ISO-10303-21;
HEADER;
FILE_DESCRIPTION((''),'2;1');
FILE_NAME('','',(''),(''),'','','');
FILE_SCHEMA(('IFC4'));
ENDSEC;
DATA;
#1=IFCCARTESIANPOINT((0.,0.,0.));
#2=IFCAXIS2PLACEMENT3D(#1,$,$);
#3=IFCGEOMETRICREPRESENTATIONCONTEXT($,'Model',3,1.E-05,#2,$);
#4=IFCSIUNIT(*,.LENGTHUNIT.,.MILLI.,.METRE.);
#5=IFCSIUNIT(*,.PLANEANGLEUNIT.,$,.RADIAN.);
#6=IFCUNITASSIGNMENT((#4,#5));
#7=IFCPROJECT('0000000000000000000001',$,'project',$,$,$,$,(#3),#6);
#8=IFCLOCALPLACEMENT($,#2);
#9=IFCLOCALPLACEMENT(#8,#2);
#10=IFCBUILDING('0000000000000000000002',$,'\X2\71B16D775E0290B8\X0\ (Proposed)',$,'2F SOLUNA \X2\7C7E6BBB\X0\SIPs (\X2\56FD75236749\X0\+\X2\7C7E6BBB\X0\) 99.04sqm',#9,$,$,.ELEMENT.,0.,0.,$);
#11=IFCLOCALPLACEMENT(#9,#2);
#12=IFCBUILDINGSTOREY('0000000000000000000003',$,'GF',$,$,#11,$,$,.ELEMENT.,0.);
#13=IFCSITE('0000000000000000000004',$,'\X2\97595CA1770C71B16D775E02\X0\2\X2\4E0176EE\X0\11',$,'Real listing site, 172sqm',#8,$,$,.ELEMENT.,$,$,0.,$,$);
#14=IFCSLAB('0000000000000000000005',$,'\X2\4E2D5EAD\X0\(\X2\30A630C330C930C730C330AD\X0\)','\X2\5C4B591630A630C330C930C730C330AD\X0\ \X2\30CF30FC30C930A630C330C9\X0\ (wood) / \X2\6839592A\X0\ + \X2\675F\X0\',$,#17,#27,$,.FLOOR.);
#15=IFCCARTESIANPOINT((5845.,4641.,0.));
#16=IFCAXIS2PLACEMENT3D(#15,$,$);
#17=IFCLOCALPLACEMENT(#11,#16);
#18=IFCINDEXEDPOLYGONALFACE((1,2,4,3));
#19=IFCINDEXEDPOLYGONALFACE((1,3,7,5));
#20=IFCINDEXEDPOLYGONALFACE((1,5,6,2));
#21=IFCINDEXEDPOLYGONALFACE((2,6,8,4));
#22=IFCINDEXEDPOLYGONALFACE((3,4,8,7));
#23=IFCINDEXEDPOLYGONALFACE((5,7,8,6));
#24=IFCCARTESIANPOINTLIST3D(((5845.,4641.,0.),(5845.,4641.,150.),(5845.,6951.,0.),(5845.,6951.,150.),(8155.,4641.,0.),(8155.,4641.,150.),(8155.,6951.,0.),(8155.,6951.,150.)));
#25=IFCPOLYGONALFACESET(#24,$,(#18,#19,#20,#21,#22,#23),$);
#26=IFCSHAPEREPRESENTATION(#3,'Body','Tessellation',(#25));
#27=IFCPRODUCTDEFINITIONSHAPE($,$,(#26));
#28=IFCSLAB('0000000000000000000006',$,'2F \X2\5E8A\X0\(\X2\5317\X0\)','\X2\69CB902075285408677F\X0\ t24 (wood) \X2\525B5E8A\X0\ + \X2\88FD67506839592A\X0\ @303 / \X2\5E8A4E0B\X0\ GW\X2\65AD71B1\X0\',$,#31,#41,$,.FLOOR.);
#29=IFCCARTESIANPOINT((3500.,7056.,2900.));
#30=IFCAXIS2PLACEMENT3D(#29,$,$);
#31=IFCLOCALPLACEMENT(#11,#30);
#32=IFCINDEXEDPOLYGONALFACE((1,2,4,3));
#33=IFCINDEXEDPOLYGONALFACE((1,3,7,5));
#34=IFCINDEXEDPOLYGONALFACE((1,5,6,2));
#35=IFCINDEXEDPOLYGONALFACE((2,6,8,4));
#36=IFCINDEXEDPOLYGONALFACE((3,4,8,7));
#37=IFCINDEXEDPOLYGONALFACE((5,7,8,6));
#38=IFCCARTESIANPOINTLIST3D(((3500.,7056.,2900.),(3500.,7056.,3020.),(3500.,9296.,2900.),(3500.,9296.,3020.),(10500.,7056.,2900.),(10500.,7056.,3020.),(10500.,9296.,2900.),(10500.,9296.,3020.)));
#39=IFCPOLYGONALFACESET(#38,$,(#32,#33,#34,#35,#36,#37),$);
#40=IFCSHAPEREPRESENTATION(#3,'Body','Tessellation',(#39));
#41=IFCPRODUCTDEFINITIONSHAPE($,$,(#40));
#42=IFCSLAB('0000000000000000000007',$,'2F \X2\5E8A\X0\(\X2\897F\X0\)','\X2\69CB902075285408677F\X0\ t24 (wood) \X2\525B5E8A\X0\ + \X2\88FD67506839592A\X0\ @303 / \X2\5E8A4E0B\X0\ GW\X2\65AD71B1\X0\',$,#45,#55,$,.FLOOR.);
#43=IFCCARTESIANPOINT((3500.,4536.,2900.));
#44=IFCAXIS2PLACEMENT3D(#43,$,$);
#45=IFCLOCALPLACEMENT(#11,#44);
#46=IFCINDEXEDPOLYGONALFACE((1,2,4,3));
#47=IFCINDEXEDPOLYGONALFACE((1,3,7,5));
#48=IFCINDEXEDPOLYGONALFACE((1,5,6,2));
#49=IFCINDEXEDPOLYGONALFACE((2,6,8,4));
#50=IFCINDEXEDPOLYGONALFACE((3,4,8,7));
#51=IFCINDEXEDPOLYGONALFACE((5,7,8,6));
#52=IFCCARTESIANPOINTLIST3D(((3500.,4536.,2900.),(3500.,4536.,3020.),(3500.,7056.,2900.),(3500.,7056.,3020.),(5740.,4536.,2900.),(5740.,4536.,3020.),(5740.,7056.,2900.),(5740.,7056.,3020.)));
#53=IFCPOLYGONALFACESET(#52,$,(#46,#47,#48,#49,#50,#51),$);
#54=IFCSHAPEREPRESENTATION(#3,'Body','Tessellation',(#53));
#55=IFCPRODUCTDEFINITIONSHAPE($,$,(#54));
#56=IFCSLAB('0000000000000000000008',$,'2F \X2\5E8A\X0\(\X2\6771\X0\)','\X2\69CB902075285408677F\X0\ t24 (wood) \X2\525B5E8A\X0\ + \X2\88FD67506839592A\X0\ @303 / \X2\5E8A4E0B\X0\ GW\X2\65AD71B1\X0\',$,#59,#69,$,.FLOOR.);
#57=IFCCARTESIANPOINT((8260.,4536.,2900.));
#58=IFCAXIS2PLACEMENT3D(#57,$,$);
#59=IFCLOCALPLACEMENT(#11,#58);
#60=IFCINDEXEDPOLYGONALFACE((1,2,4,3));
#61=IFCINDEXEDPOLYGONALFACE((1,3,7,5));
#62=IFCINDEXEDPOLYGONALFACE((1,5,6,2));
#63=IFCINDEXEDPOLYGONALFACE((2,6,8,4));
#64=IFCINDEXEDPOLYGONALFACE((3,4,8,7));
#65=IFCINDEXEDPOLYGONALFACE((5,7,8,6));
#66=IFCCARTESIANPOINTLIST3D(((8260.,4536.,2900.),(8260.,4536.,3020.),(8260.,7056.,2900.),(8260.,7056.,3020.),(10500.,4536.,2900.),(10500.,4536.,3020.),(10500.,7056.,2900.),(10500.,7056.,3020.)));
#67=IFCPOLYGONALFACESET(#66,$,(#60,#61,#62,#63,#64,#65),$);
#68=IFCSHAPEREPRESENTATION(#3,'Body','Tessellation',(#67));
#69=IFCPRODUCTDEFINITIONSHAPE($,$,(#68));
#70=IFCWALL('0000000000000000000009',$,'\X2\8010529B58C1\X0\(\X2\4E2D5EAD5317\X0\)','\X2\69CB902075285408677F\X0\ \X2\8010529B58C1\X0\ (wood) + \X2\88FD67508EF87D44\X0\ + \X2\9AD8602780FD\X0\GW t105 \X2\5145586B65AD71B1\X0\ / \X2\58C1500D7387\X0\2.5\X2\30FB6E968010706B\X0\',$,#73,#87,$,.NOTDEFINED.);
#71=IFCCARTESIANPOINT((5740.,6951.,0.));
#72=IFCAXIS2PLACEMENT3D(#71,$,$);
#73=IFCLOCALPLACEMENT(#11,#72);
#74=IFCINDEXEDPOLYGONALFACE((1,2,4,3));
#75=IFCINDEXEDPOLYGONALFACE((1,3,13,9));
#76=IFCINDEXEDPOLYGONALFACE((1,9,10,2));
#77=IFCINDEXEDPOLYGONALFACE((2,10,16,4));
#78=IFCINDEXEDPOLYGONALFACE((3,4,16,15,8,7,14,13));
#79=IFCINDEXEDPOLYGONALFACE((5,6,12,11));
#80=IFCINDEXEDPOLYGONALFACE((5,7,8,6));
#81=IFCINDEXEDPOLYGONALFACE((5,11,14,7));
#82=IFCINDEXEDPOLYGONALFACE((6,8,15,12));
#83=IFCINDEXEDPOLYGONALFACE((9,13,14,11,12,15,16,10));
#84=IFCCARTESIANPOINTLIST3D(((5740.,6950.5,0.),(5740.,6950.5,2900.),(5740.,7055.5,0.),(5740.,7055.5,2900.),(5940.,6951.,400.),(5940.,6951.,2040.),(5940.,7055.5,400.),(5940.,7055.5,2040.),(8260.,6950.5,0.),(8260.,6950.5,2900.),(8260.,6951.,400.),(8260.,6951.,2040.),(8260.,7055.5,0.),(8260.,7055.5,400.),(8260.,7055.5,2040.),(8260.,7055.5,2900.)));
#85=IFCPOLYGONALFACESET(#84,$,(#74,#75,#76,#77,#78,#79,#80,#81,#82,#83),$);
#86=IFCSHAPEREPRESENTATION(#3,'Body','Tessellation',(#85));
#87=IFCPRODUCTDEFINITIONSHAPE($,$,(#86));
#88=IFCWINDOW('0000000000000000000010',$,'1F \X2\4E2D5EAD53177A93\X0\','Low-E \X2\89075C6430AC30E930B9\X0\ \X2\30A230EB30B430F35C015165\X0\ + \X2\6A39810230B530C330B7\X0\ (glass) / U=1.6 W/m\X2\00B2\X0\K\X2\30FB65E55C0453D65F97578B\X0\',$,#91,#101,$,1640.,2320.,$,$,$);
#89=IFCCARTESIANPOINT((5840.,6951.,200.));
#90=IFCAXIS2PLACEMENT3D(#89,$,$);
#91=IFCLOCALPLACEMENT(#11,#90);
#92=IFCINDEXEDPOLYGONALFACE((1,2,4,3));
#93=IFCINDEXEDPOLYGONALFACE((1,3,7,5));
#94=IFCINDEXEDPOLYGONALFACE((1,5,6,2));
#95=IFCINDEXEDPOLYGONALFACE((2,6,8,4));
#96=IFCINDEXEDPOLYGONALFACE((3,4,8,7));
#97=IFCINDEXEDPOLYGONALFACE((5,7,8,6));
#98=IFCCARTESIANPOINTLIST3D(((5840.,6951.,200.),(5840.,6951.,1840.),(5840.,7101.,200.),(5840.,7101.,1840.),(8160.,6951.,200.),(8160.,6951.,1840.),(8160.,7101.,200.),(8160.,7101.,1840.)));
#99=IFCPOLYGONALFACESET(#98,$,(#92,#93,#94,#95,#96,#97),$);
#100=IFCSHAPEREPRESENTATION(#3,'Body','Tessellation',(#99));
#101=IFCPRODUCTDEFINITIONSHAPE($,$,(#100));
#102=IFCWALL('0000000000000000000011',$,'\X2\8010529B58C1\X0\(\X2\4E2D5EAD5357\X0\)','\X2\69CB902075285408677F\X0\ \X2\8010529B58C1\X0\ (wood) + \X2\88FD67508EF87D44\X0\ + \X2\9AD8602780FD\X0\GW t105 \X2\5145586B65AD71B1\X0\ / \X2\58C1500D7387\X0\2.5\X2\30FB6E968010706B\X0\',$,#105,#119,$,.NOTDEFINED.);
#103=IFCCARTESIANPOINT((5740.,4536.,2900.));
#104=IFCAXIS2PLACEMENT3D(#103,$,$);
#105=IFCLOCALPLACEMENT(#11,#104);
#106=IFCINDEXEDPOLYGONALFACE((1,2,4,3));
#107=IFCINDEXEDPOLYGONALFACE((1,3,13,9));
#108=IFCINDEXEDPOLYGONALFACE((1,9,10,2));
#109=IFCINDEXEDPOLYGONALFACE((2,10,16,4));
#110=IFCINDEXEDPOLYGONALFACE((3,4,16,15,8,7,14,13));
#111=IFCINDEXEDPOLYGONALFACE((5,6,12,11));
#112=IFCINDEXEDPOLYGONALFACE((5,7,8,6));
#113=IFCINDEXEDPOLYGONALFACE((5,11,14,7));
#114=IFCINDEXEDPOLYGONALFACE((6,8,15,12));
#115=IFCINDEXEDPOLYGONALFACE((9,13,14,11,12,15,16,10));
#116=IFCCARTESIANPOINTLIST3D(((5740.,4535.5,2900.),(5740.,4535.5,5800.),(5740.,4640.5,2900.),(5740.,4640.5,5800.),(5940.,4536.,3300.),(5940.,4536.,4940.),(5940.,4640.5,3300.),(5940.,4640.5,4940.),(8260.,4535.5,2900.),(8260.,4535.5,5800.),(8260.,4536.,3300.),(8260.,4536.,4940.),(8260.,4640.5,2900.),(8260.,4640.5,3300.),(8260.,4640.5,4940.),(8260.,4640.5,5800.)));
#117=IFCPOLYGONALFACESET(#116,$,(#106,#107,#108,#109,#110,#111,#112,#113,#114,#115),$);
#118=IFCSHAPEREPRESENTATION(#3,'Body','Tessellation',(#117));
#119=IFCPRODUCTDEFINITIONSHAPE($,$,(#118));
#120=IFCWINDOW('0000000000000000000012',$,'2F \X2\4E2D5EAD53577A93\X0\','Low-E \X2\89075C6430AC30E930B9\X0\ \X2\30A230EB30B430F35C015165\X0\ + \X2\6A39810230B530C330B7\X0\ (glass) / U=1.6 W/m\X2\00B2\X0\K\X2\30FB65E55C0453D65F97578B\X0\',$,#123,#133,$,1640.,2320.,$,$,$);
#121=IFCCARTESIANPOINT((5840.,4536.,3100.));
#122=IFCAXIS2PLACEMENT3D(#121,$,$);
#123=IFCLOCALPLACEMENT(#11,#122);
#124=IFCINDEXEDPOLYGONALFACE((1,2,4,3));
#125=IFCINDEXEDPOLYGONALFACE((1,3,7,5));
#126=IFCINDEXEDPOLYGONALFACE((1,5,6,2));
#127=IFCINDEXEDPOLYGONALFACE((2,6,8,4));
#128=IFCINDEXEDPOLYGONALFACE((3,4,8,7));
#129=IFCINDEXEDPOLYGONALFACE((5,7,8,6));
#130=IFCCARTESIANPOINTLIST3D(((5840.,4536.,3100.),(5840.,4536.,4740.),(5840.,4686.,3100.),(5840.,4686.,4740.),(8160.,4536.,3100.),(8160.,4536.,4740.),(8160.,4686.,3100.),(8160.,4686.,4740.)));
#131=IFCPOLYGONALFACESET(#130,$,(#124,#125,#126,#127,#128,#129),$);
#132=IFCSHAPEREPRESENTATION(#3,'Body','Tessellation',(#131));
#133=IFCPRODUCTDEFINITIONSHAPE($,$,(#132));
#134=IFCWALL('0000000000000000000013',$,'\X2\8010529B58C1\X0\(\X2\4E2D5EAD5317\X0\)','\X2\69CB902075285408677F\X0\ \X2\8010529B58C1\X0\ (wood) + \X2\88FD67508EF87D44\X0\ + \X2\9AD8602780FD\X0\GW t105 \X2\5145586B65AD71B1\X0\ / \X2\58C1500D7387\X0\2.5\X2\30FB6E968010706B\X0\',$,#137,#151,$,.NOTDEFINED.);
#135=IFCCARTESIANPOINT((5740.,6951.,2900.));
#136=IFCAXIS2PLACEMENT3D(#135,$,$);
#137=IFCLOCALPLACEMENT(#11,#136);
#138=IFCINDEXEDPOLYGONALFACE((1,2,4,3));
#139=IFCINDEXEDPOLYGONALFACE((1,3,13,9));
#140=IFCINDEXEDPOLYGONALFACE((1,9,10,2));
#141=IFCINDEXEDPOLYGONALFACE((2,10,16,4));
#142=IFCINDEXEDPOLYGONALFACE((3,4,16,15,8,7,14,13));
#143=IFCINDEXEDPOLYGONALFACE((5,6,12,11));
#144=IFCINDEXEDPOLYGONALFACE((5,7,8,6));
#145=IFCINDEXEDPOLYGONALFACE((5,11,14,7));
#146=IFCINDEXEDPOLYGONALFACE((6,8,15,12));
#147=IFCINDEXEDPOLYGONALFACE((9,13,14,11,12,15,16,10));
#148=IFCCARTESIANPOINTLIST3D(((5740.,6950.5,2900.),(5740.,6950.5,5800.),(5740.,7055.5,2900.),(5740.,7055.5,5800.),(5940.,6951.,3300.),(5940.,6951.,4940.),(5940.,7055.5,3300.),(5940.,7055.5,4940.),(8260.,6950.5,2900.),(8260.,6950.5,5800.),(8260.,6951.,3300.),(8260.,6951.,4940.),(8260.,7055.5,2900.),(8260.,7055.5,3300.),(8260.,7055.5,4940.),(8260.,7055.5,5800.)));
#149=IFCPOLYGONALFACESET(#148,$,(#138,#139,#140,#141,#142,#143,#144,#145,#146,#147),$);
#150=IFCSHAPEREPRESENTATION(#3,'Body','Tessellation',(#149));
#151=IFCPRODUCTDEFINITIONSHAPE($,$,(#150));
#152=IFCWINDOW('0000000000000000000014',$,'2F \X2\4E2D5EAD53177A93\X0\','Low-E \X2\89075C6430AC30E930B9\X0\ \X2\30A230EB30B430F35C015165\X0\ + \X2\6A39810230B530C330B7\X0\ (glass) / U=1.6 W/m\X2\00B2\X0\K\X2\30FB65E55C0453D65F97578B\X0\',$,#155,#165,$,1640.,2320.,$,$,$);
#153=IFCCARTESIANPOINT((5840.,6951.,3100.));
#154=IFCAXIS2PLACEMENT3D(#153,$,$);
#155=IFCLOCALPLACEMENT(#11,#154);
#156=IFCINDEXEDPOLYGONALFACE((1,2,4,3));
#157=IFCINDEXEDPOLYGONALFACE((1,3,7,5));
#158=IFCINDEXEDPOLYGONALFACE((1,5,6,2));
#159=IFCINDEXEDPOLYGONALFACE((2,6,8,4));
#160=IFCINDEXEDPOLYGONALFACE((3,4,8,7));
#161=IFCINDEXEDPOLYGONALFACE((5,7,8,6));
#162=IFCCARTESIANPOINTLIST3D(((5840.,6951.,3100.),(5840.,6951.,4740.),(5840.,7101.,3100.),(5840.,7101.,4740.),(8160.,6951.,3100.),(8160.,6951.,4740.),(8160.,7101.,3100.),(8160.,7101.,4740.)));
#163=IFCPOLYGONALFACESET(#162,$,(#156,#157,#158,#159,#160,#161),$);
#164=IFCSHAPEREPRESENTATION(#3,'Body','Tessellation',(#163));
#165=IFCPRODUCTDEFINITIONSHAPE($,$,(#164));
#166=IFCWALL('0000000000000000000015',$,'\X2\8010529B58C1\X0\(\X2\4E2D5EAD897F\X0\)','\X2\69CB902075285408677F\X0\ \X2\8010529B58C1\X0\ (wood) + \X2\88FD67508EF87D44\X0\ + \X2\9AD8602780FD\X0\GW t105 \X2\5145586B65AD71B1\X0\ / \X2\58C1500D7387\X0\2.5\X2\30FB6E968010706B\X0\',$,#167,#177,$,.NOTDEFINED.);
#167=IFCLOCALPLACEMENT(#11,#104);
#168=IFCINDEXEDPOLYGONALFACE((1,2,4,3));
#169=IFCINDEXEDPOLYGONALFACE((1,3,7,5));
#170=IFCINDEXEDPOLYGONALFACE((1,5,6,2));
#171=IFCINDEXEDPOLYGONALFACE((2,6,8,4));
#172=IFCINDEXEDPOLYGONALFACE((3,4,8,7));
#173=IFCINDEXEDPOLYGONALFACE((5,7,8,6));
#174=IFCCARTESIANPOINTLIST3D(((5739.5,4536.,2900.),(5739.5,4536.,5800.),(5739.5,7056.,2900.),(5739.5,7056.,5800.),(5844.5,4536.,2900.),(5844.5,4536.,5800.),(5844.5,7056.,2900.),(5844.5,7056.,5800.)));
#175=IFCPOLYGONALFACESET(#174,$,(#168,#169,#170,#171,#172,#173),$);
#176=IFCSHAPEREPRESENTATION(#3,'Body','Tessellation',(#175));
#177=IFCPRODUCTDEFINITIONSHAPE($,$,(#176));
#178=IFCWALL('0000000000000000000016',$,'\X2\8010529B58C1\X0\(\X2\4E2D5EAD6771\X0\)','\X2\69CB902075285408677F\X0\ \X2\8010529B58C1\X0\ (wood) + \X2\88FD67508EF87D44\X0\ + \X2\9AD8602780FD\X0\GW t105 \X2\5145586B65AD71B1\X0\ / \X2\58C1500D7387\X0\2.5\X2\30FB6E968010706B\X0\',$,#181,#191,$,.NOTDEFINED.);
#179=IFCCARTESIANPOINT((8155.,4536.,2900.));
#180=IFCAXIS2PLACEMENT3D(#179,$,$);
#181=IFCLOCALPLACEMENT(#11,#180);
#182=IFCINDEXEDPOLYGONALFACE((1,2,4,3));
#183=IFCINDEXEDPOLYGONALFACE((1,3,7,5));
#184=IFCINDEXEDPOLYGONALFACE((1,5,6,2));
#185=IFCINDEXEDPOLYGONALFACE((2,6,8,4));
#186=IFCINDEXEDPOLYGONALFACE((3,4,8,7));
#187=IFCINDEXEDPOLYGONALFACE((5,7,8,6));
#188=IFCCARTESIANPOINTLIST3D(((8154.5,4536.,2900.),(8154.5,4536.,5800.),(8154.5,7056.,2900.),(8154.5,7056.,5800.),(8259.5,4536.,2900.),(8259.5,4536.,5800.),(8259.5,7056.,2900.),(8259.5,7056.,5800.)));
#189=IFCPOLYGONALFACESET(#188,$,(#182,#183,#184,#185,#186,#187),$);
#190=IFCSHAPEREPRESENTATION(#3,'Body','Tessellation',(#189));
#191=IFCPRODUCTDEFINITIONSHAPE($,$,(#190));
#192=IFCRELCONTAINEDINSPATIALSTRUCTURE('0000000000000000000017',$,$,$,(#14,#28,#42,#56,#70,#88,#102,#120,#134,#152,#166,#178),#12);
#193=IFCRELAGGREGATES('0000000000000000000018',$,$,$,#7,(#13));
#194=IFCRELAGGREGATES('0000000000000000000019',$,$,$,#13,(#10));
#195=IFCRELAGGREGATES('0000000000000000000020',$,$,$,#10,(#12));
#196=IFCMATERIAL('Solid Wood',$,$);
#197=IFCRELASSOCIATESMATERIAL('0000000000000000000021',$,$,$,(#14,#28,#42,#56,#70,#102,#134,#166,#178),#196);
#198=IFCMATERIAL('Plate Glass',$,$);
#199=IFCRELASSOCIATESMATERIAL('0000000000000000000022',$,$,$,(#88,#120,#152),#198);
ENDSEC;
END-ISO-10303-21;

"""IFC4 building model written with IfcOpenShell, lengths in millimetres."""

from ifc_helpers import new_model, si_unit, frame, frame_2d, origin, place, context, project, spatial, rectangle, extrude, material, element, fill, save


model = new_model("IFC4")

# Units and contexts
model_context = context("Model", 3, precision=1e-05, world=origin())
ifc_project = project(units=[si_unit("LENGTHUNIT", "METRE", prefix="MILLI"), si_unit("PLANEANGLEUNIT", "RADIAN")], contexts=[model_context])

# Site, building, storey
site_placement = place(None, origin())
site = spatial("IfcSite", under=ifc_project, at=site_placement, Name="静岡県熱海市2丁目11", ObjectType="Real listing site, 172sqm", CompositionType="ELEMENT", RefElevation=0.0)
building_placement = place(site_placement, origin())
building = spatial("IfcBuilding", under=site, at=building_placement, Name="熱海市邸 (Proposed)", ObjectType="2F SOLUNA 籾殻SIPs (国産杉+籾殻) 99.04sqm", CompositionType="ELEMENT", ElevationOfRefHeight=0.0, ElevationOfTerrain=0.0)
storey_placement = place(building_placement, origin())
storey = spatial("IfcBuildingStorey", under=building, at=storey_placement, Name="GF", CompositionType="ELEMENT", Elevation=0.0)

# Slabs
ifc_material_1 = material(Name="Solid Wood")
slab_1_placement = place(storey_placement, frame((5845.0, 4641.0, 0.0)))
element("IfcSlab", 1, at=slab_1_placement, inside=storey, material=ifc_material_1, Name="中庭(ウッドデッキ)", Description="屋外ウッドデッキ ハードウッド (wood) / 根太 + 束", PredefinedType="FLOOR", context=model_context, shape_type="SweptSolid", body=[
    extrude(rectangle(XDim=2310.0, YDim=2310.0, at=frame_2d((1155.0, 1155.0))), frame((5845.0, 4641.0, 0.0)), (0.0, 0.0, 1.0), 150.0),
])
slab_2_placement = place(storey_placement, frame((3500.0, 7056.0, 2900.0)))
element("IfcSlab", 2, at=slab_2_placement, inside=storey, material=ifc_material_1, Name="2F 床(北)", Description="構造用合板 t24 (wood) 剛床 + 製材根太 @303 / 床下 GW断熱", PredefinedType="FLOOR", context=model_context, shape_type="SweptSolid", body=[
    extrude(rectangle(XDim=7000.0, YDim=2240.0, at=frame_2d((3500.0, 1120.0))), frame((3500.0, 7056.0, 2900.0)), (0.0, 0.0, 1.0), 120.0),
])
slab_3_placement = place(storey_placement, frame((3500.0, 4536.0, 2900.0)))
element("IfcSlab", 3, at=slab_3_placement, inside=storey, material=ifc_material_1, Name="2F 床(西)", Description="構造用合板 t24 (wood) 剛床 + 製材根太 @303 / 床下 GW断熱", PredefinedType="FLOOR", context=model_context, shape_type="SweptSolid", body=[
    extrude(rectangle(XDim=2240.0, YDim=2520.0, at=frame_2d((1120.0, 1260.0))), frame((3500.0, 4536.0, 2900.0)), (0.0, 0.0, 1.0), 120.0),
])
slab_4_placement = place(storey_placement, frame((8260.0, 4536.0, 2900.0)))
element("IfcSlab", 4, at=slab_4_placement, inside=storey, material=ifc_material_1, Name="2F 床(東)", Description="構造用合板 t24 (wood) 剛床 + 製材根太 @303 / 床下 GW断熱", PredefinedType="FLOOR", context=model_context, shape_type="SweptSolid", body=[
    extrude(rectangle(XDim=2240.0, YDim=2520.0, at=frame_2d((1120.0, 1260.0))), frame((8260.0, 4536.0, 2900.0)), (0.0, 0.0, 1.0), 120.0),
])

# Wall, opening, window
wall_1_placement = place(storey_placement, frame((5740.0, 6951.0, 0.0)))
wall_1 = element("IfcWall", 5, at=wall_1_placement, inside=storey, material=ifc_material_1, Name="耐力壁(中庭北)", Description="構造用合板 耐力壁 (wood) + 製材軸組 + 高性能GW t105 充填断熱 / 壁倍率2.5・準耐火", PredefinedType="NOTDEFINED", context=model_context, shape_type="SweptSolid", body=[
    extrude(rectangle(XDim=2520.0, YDim=105.0, at=frame_2d((1260.0, 52.0))), frame((5740.0, 6951.0, 0.0)), (0.0, 0.0, 1.0), 2900.0),
])
opening_1_placement = place(storey_placement, frame((5840.0, 6951.0, 200.0)))
opening_1 = element("IfcOpeningElement", 6, at=opening_1_placement, cuts=wall_1, PredefinedType="NOTDEFINED", context=model_context, shape_type="SweptSolid", body=[
    extrude(rectangle(XDim=2320.0, YDim=150.0, at=frame_2d((1160.0, 75.0))), frame((5840.0, 6951.0, 200.0)), (0.0, 0.0, 1.0), 1640.0),
])
ifc_material_2 = material(Name="Plate Glass")
window_1_placement = place(storey_placement, frame((5840.0, 6951.0, 200.0)))
window_1 = element("IfcWindow", 7, at=window_1_placement, inside=storey, material=ifc_material_2, Name="1F 中庭北窓", Description="Low-E 複層ガラス アルゴン封入 + 樹脂サッシ (glass) / U=1.6 W/m²K・日射取得型", OverallHeight=1640.0, OverallWidth=2320.0, context=model_context, shape_type="SweptSolid", body=[
    extrude(rectangle(XDim=2320.0, YDim=150.0, at=frame_2d((1160.0, 75.0))), frame((5840.0, 6951.0, 200.0)), (0.0, 0.0, 1.0), 1640.0),
])
fill(opening_1, window_1)

# Walls, openings, windows
wall_2_placement = place(storey_placement, frame((5740.0, 4536.0, 2900.0)))
wall_2 = element("IfcWall", 8, at=wall_2_placement, inside=storey, material=ifc_material_1, Name="耐力壁(中庭南)", Description="構造用合板 耐力壁 (wood) + 製材軸組 + 高性能GW t105 充填断熱 / 壁倍率2.5・準耐火", PredefinedType="NOTDEFINED", context=model_context, shape_type="SweptSolid", body=[
    extrude(rectangle(XDim=2520.0, YDim=105.0, at=frame_2d((1260.0, 52.0))), frame((5740.0, 4536.0, 2900.0)), (0.0, 0.0, 1.0), 2900.0),
])
opening_2_placement = place(storey_placement, frame((5840.0, 4536.0, 3100.0)))
opening_2 = element("IfcOpeningElement", 9, at=opening_2_placement, cuts=wall_2, PredefinedType="NOTDEFINED", context=model_context, shape_type="SweptSolid", body=[
    extrude(rectangle(XDim=2320.0, YDim=150.0, at=frame_2d((1160.0, 75.0))), frame((5840.0, 4536.0, 3100.0)), (0.0, 0.0, 1.0), 1640.0),
])
window_2_placement = place(storey_placement, frame((5840.0, 4536.0, 3100.0)))
window_2 = element("IfcWindow", 10, at=window_2_placement, inside=storey, material=ifc_material_2, Name="2F 中庭南窓", Description="Low-E 複層ガラス アルゴン封入 + 樹脂サッシ (glass) / U=1.6 W/m²K・日射取得型", OverallHeight=1640.0, OverallWidth=2320.0, context=model_context, shape_type="SweptSolid", body=[
    extrude(rectangle(XDim=2320.0, YDim=150.0, at=frame_2d((1160.0, 75.0))), frame((5840.0, 4536.0, 3100.0)), (0.0, 0.0, 1.0), 1640.0),
])
fill(opening_2, window_2)
wall_3_placement = place(storey_placement, frame((5740.0, 6951.0, 2900.0)))
wall_3 = element("IfcWall", 11, at=wall_3_placement, inside=storey, material=ifc_material_1, Name="耐力壁(中庭北)", Description="構造用合板 耐力壁 (wood) + 製材軸組 + 高性能GW t105 充填断熱 / 壁倍率2.5・準耐火", PredefinedType="NOTDEFINED", context=model_context, shape_type="SweptSolid", body=[
    extrude(rectangle(XDim=2520.0, YDim=105.0, at=frame_2d((1260.0, 52.0))), frame((5740.0, 6951.0, 2900.0)), (0.0, 0.0, 1.0), 2900.0),
])
opening_3_placement = place(storey_placement, frame((5840.0, 6951.0, 3100.0)))
opening_3 = element("IfcOpeningElement", 12, at=opening_3_placement, cuts=wall_3, PredefinedType="NOTDEFINED", context=model_context, shape_type="SweptSolid", body=[
    extrude(rectangle(XDim=2320.0, YDim=150.0, at=frame_2d((1160.0, 75.0))), frame((5840.0, 6951.0, 3100.0)), (0.0, 0.0, 1.0), 1640.0),
])
window_3_placement = place(storey_placement, frame((5840.0, 6951.0, 3100.0)))
window_3 = element("IfcWindow", 13, at=window_3_placement, inside=storey, material=ifc_material_2, Name="2F 中庭北窓", Description="Low-E 複層ガラス アルゴン封入 + 樹脂サッシ (glass) / U=1.6 W/m²K・日射取得型", OverallHeight=1640.0, OverallWidth=2320.0, context=model_context, shape_type="SweptSolid", body=[
    extrude(rectangle(XDim=2320.0, YDim=150.0, at=frame_2d((1160.0, 75.0))), frame((5840.0, 6951.0, 3100.0)), (0.0, 0.0, 1.0), 1640.0),
])
fill(opening_3, window_3)

# Walls
wall_4_placement = place(storey_placement, frame((5740.0, 4536.0, 2900.0)))
element("IfcWall", 14, at=wall_4_placement, inside=storey, material=ifc_material_1, Name="耐力壁(中庭西)", Description="構造用合板 耐力壁 (wood) + 製材軸組 + 高性能GW t105 充填断熱 / 壁倍率2.5・準耐火", PredefinedType="NOTDEFINED", context=model_context, shape_type="SweptSolid", body=[
    extrude(rectangle(XDim=105.0, YDim=2520.0, at=frame_2d((52.0, 1260.0))), frame((5740.0, 4536.0, 2900.0)), (0.0, 0.0, 1.0), 2900.0),
])
wall_5_placement = place(storey_placement, frame((8155.0, 4536.0, 2900.0)))
element("IfcWall", 15, at=wall_5_placement, inside=storey, material=ifc_material_1, Name="耐力壁(中庭東)", Description="構造用合板 耐力壁 (wood) + 製材軸組 + 高性能GW t105 充填断熱 / 壁倍率2.5・準耐火", PredefinedType="NOTDEFINED", context=model_context, shape_type="SweptSolid", body=[
    extrude(rectangle(XDim=105.0, YDim=2520.0, at=frame_2d((52.0, 1260.0))), frame((8155.0, 4536.0, 2900.0)), (0.0, 0.0, 1.0), 2900.0),
])

save(model, "model.ifc")
